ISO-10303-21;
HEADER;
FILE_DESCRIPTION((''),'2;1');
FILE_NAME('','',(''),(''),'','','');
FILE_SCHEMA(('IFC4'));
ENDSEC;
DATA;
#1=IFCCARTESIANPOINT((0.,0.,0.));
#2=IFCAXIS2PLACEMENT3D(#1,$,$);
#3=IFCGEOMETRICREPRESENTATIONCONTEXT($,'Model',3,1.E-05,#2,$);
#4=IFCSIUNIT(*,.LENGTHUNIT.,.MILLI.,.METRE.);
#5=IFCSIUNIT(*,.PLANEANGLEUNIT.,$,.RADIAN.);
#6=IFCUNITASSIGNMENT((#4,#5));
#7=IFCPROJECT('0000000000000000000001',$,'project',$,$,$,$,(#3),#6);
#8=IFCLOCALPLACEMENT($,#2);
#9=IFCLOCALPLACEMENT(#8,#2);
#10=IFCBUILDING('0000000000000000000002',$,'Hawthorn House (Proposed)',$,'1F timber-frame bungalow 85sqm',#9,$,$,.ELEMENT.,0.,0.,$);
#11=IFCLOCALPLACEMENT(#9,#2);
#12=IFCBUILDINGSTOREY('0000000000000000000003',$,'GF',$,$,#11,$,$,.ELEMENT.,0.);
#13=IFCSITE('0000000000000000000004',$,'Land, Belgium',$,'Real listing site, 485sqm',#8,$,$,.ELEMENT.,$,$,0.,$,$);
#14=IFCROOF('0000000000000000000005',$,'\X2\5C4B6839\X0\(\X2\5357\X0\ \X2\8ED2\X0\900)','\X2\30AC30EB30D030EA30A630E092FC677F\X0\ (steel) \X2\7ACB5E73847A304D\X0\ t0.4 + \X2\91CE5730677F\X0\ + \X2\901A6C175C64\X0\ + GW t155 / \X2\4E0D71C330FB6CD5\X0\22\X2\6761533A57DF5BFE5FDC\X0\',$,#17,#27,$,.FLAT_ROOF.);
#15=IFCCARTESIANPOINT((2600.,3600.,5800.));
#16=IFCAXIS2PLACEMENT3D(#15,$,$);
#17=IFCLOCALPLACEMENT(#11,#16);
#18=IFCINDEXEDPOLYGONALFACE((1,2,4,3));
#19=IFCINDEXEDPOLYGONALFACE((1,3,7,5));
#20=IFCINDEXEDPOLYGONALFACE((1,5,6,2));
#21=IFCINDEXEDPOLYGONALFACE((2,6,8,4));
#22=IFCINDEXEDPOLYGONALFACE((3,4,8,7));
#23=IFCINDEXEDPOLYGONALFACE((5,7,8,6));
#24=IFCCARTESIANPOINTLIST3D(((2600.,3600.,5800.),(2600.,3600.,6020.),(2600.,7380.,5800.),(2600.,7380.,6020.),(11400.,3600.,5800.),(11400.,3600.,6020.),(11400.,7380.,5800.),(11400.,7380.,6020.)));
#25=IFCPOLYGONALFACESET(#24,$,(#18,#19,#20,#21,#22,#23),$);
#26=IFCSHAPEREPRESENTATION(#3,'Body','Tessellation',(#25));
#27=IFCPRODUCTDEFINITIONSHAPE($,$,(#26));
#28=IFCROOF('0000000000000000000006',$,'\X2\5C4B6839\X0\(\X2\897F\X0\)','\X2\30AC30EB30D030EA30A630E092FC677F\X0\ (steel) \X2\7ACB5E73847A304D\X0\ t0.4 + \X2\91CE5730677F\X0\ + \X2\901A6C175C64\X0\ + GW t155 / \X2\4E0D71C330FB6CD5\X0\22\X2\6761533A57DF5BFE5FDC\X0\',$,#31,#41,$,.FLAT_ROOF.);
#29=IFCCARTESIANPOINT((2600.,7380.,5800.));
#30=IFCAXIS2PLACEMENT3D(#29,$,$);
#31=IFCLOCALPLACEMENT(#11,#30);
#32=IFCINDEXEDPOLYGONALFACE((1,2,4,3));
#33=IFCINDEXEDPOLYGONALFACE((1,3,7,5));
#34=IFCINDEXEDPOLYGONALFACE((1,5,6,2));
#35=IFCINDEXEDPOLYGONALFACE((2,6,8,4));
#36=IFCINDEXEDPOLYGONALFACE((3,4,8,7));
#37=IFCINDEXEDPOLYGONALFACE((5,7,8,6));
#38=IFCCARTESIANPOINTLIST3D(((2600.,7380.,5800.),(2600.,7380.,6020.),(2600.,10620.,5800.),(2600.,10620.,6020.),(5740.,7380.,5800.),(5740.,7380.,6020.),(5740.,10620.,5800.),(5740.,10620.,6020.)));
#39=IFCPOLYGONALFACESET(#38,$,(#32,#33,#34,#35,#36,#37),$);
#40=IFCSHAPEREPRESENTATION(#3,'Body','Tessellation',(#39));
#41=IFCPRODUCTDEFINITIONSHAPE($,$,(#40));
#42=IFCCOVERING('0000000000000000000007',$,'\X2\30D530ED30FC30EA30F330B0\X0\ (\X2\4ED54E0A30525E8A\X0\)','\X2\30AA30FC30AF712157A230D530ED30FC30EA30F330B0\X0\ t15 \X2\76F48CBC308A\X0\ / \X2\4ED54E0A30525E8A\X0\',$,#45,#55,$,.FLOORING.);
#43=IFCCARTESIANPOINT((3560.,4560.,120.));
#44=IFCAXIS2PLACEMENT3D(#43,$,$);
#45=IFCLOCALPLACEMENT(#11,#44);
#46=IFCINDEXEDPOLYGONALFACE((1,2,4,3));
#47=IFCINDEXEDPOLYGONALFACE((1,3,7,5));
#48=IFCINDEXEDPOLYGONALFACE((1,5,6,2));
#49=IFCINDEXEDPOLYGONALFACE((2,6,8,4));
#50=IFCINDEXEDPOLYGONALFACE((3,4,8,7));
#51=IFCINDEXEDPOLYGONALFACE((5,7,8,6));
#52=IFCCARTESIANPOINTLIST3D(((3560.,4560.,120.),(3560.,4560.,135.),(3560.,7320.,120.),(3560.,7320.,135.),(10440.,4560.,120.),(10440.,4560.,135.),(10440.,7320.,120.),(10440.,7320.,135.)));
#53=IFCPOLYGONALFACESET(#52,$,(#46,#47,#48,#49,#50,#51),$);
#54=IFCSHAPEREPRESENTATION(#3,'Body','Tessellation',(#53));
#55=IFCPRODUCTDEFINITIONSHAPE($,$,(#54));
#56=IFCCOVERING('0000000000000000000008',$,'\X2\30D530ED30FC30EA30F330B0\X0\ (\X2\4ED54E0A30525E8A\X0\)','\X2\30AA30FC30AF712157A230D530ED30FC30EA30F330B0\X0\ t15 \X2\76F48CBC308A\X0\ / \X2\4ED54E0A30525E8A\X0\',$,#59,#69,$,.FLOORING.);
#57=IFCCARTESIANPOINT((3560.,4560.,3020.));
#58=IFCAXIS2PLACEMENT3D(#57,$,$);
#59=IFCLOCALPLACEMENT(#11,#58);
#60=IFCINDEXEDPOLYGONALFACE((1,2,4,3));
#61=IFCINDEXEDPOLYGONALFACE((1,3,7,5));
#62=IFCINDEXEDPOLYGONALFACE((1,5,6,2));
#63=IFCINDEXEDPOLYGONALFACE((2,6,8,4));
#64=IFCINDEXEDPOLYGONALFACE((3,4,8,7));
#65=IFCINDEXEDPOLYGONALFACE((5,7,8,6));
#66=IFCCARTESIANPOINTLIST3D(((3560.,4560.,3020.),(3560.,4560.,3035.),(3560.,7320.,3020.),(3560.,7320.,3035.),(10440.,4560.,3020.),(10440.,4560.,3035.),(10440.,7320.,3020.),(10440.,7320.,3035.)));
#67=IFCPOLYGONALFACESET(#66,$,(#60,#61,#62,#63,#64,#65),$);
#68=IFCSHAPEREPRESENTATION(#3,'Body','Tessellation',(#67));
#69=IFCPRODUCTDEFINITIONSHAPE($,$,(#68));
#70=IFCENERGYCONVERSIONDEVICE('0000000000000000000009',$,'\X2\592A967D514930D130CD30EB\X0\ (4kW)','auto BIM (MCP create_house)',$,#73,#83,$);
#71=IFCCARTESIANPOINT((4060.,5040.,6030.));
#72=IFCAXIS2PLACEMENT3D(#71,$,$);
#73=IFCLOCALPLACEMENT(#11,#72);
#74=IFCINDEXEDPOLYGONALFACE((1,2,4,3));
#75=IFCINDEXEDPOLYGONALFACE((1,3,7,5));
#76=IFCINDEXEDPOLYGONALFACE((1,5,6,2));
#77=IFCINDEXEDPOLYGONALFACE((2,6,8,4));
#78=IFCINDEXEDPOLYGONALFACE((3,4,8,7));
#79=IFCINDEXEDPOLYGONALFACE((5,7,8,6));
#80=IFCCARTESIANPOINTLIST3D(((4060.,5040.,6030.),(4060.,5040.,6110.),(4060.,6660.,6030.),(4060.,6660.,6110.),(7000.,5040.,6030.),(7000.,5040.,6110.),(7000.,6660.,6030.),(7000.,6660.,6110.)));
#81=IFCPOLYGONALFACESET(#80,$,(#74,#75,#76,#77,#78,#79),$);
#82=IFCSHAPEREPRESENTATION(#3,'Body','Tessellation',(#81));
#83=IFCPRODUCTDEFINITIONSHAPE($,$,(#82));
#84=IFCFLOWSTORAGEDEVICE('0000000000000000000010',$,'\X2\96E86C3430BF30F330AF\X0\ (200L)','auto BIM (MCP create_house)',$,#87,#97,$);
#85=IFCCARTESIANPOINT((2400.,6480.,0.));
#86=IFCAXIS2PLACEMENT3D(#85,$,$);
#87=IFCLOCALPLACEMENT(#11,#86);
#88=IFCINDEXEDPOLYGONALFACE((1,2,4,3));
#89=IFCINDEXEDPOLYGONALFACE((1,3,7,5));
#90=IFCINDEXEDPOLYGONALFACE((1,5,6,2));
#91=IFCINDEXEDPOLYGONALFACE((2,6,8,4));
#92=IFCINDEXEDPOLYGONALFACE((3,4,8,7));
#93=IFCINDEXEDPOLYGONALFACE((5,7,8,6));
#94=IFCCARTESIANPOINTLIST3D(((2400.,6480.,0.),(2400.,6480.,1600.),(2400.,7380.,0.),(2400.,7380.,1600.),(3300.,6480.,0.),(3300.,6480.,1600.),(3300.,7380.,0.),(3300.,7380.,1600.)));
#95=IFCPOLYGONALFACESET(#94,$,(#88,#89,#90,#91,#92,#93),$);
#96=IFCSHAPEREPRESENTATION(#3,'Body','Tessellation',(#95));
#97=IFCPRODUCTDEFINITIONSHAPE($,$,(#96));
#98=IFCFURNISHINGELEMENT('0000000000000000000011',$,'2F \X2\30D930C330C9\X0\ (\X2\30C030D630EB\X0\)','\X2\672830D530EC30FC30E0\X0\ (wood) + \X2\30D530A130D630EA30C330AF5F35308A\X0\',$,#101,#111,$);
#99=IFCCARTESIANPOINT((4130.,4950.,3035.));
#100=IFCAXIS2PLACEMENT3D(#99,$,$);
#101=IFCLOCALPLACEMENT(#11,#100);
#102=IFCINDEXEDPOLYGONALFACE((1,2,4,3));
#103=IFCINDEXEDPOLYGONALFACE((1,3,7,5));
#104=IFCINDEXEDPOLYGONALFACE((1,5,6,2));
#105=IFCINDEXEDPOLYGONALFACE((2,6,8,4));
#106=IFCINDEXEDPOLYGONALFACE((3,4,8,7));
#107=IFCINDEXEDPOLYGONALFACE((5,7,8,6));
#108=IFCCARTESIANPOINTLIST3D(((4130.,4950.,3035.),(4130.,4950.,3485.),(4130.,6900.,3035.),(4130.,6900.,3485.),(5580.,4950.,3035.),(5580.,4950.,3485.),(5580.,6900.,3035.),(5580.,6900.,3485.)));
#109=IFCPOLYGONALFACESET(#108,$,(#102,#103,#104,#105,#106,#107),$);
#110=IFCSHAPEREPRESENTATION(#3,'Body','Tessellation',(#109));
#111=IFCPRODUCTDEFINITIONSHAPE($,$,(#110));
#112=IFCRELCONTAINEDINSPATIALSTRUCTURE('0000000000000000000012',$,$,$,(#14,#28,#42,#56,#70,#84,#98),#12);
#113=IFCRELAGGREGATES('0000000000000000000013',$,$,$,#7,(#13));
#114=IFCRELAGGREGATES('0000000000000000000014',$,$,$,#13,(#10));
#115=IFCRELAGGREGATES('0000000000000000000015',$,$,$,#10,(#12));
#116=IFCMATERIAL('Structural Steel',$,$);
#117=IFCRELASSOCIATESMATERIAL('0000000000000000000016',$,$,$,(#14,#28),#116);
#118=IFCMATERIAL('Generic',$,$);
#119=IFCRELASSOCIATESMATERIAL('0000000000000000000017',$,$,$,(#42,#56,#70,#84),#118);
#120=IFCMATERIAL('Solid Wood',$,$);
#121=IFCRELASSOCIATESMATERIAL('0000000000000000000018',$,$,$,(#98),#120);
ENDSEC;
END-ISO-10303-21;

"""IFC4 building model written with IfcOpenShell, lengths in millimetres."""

from ifc_helpers import new_model, si_unit, frame, frame_2d, origin, place, context, project, spatial, rectangle, extrude, material, element, save


model = new_model("IFC4")

# Units and contexts
model_context = context("Model", 3, precision=1e-05, world=origin())
ifc_project = project(units=[si_unit("LENGTHUNIT", "METRE", prefix="MILLI"), si_unit("PLANEANGLEUNIT", "RADIAN")], contexts=[model_context])

# Site, building, storey
site_placement = place(None, origin())
site = spatial("IfcSite", under=ifc_project, at=site_placement, Name="Land, Belgium", ObjectType="Real listing site, 485sqm", CompositionType="ELEMENT", RefElevation=0.0)
building_placement = place(site_placement, origin())
building = spatial("IfcBuilding", under=site, at=building_placement, Name="Hawthorn House (Proposed)", ObjectType="1F timber-frame bungalow 85sqm", CompositionType="ELEMENT", ElevationOfRefHeight=0.0, ElevationOfTerrain=0.0)
storey_placement = place(building_placement, origin())
storey = spatial("IfcBuildingStorey", under=building, at=storey_placement, Name="GF", CompositionType="ELEMENT", Elevation=0.0)

# Shared definitions
ifc_material_1 = material(Name="Solid Wood")
ifc_material_2 = material(Name="Generic")

# Roofs
ifc_material_3 = material(Name="Structural Steel")
roof_1_placement = place(storey_placement, frame((2600.0, 3600.0, 5800.0)))
element("IfcRoof", 1, at=roof_1_placement, inside=storey, material=ifc_material_3, Name="屋根(南 軒900)", Description="ガルバリウム鋼板 (steel) 立平葺き t0.4 + 野地板 + 通気層 + GW t155 / 不燃・法22条区域対応", PredefinedType="FLAT_ROOF", context=model_context, shape_type="SweptSolid", body=[
    extrude(rectangle(XDim=8800.0, YDim=3780.0, at=frame_2d((4400.0, 1890.0))), frame((2600.0, 3600.0, 5800.0)), (0.0, 0.0, 1.0), 220.0),
])
roof_2_placement = place(storey_placement, frame((2600.0, 7380.0, 5800.0)))
element("IfcRoof", 2, at=roof_2_placement, inside=storey, material=ifc_material_3, Name="屋根(西)", Description="ガルバリウム鋼板 (steel) 立平葺き t0.4 + 野地板 + 通気層 + GW t155 / 不燃・法22条区域対応", PredefinedType="FLAT_ROOF", context=model_context, shape_type="SweptSolid", body=[
    extrude(rectangle(XDim=3140.0, YDim=3240.0, at=frame_2d((1570.0, 1620.0))), frame((2600.0, 7380.0, 5800.0)), (0.0, 0.0, 1.0), 220.0),
])

# Coverings
covering_1_placement = place(storey_placement, frame((3560.0, 4560.0, 120.0)))
element("IfcCovering", 3, at=covering_1_placement, inside=storey, material=ifc_material_2, Name="フローリング (仕上げ床)", Description="オーク無垢フローリング t15 直貼り / 仕上げ床", PredefinedType="FLOORING", context=model_context, shape_type="SweptSolid", body=[
    extrude(rectangle(XDim=6880.0, YDim=2760.0, at=frame_2d((3440.0, 1380.0))), frame((3560.0, 4560.0, 120.0)), (0.0, 0.0, 1.0), 15.0),
])
covering_2_placement = place(storey_placement, frame((3560.0, 4560.0, 3020.0)))
element("IfcCovering", 4, at=covering_2_placement, inside=storey, material=ifc_material_2, Name="フローリング (仕上げ床)", Description="オーク無垢フローリング t15 直貼り / 仕上げ床", PredefinedType="FLOORING", context=model_context, shape_type="SweptSolid", body=[
    extrude(rectangle(XDim=6880.0, YDim=2760.0, at=frame_2d((3440.0, 1380.0))), frame((3560.0, 4560.0, 3020.0)), (0.0, 0.0, 1.0), 15.0),
])

# Energy conversion device
energy_conversion_device_placement = place(storey_placement, frame((4060.0, 5040.0, 6030.0)))
element("IfcEnergyConversionDevice", 5, at=energy_conversion_device_placement, inside=storey, material=ifc_material_2, Name="太陽光パネル (4kW)", Description="auto BIM (MCP create_house)", context=model_context, shape_type="SweptSolid", body=[
    extrude(rectangle(XDim=2940.0, YDim=1620.0, at=frame_2d((1470.0, 810.0))), frame((4060.0, 5040.0, 6030.0)), (0.0, 0.0, 1.0), 80.0),
])

# Flow storage device
flow_storage_device_placement = place(storey_placement, frame((2400.0, 6480.0, 0.0)))
element("IfcFlowStorageDevice", 6, at=flow_storage_device_placement, inside=storey, material=ifc_material_2, Name="雨水タンク (200L)", Description="auto BIM (MCP create_house)", context=model_context, shape_type="SweptSolid", body=[
    extrude(rectangle(XDim=900.0, YDim=900.0, at=frame_2d((450.0, 450.0))), frame((2400.0, 6480.0, 0.0)), (0.0, 0.0, 1.0), 1600.0),
])

# Furnishing element
furnishing_placement = place(storey_placement, frame((4130.0, 4950.0, 3035.0)))
element("IfcFurnishingElement", 7, at=furnishing_placement, inside=storey, material=ifc_material_1, Name="2F ベッド (ダブル)", Description="木フレーム (wood) + ファブリック張り", context=model_context, shape_type="SweptSolid", body=[
    extrude(rectangle(XDim=1450.0, YDim=1950.0, at=frame_2d((725.0, 975.0))), frame((4130.0, 4950.0, 3035.0)), (0.0, 0.0, 1.0), 450.0),
])

save(model, "model.ifc")
